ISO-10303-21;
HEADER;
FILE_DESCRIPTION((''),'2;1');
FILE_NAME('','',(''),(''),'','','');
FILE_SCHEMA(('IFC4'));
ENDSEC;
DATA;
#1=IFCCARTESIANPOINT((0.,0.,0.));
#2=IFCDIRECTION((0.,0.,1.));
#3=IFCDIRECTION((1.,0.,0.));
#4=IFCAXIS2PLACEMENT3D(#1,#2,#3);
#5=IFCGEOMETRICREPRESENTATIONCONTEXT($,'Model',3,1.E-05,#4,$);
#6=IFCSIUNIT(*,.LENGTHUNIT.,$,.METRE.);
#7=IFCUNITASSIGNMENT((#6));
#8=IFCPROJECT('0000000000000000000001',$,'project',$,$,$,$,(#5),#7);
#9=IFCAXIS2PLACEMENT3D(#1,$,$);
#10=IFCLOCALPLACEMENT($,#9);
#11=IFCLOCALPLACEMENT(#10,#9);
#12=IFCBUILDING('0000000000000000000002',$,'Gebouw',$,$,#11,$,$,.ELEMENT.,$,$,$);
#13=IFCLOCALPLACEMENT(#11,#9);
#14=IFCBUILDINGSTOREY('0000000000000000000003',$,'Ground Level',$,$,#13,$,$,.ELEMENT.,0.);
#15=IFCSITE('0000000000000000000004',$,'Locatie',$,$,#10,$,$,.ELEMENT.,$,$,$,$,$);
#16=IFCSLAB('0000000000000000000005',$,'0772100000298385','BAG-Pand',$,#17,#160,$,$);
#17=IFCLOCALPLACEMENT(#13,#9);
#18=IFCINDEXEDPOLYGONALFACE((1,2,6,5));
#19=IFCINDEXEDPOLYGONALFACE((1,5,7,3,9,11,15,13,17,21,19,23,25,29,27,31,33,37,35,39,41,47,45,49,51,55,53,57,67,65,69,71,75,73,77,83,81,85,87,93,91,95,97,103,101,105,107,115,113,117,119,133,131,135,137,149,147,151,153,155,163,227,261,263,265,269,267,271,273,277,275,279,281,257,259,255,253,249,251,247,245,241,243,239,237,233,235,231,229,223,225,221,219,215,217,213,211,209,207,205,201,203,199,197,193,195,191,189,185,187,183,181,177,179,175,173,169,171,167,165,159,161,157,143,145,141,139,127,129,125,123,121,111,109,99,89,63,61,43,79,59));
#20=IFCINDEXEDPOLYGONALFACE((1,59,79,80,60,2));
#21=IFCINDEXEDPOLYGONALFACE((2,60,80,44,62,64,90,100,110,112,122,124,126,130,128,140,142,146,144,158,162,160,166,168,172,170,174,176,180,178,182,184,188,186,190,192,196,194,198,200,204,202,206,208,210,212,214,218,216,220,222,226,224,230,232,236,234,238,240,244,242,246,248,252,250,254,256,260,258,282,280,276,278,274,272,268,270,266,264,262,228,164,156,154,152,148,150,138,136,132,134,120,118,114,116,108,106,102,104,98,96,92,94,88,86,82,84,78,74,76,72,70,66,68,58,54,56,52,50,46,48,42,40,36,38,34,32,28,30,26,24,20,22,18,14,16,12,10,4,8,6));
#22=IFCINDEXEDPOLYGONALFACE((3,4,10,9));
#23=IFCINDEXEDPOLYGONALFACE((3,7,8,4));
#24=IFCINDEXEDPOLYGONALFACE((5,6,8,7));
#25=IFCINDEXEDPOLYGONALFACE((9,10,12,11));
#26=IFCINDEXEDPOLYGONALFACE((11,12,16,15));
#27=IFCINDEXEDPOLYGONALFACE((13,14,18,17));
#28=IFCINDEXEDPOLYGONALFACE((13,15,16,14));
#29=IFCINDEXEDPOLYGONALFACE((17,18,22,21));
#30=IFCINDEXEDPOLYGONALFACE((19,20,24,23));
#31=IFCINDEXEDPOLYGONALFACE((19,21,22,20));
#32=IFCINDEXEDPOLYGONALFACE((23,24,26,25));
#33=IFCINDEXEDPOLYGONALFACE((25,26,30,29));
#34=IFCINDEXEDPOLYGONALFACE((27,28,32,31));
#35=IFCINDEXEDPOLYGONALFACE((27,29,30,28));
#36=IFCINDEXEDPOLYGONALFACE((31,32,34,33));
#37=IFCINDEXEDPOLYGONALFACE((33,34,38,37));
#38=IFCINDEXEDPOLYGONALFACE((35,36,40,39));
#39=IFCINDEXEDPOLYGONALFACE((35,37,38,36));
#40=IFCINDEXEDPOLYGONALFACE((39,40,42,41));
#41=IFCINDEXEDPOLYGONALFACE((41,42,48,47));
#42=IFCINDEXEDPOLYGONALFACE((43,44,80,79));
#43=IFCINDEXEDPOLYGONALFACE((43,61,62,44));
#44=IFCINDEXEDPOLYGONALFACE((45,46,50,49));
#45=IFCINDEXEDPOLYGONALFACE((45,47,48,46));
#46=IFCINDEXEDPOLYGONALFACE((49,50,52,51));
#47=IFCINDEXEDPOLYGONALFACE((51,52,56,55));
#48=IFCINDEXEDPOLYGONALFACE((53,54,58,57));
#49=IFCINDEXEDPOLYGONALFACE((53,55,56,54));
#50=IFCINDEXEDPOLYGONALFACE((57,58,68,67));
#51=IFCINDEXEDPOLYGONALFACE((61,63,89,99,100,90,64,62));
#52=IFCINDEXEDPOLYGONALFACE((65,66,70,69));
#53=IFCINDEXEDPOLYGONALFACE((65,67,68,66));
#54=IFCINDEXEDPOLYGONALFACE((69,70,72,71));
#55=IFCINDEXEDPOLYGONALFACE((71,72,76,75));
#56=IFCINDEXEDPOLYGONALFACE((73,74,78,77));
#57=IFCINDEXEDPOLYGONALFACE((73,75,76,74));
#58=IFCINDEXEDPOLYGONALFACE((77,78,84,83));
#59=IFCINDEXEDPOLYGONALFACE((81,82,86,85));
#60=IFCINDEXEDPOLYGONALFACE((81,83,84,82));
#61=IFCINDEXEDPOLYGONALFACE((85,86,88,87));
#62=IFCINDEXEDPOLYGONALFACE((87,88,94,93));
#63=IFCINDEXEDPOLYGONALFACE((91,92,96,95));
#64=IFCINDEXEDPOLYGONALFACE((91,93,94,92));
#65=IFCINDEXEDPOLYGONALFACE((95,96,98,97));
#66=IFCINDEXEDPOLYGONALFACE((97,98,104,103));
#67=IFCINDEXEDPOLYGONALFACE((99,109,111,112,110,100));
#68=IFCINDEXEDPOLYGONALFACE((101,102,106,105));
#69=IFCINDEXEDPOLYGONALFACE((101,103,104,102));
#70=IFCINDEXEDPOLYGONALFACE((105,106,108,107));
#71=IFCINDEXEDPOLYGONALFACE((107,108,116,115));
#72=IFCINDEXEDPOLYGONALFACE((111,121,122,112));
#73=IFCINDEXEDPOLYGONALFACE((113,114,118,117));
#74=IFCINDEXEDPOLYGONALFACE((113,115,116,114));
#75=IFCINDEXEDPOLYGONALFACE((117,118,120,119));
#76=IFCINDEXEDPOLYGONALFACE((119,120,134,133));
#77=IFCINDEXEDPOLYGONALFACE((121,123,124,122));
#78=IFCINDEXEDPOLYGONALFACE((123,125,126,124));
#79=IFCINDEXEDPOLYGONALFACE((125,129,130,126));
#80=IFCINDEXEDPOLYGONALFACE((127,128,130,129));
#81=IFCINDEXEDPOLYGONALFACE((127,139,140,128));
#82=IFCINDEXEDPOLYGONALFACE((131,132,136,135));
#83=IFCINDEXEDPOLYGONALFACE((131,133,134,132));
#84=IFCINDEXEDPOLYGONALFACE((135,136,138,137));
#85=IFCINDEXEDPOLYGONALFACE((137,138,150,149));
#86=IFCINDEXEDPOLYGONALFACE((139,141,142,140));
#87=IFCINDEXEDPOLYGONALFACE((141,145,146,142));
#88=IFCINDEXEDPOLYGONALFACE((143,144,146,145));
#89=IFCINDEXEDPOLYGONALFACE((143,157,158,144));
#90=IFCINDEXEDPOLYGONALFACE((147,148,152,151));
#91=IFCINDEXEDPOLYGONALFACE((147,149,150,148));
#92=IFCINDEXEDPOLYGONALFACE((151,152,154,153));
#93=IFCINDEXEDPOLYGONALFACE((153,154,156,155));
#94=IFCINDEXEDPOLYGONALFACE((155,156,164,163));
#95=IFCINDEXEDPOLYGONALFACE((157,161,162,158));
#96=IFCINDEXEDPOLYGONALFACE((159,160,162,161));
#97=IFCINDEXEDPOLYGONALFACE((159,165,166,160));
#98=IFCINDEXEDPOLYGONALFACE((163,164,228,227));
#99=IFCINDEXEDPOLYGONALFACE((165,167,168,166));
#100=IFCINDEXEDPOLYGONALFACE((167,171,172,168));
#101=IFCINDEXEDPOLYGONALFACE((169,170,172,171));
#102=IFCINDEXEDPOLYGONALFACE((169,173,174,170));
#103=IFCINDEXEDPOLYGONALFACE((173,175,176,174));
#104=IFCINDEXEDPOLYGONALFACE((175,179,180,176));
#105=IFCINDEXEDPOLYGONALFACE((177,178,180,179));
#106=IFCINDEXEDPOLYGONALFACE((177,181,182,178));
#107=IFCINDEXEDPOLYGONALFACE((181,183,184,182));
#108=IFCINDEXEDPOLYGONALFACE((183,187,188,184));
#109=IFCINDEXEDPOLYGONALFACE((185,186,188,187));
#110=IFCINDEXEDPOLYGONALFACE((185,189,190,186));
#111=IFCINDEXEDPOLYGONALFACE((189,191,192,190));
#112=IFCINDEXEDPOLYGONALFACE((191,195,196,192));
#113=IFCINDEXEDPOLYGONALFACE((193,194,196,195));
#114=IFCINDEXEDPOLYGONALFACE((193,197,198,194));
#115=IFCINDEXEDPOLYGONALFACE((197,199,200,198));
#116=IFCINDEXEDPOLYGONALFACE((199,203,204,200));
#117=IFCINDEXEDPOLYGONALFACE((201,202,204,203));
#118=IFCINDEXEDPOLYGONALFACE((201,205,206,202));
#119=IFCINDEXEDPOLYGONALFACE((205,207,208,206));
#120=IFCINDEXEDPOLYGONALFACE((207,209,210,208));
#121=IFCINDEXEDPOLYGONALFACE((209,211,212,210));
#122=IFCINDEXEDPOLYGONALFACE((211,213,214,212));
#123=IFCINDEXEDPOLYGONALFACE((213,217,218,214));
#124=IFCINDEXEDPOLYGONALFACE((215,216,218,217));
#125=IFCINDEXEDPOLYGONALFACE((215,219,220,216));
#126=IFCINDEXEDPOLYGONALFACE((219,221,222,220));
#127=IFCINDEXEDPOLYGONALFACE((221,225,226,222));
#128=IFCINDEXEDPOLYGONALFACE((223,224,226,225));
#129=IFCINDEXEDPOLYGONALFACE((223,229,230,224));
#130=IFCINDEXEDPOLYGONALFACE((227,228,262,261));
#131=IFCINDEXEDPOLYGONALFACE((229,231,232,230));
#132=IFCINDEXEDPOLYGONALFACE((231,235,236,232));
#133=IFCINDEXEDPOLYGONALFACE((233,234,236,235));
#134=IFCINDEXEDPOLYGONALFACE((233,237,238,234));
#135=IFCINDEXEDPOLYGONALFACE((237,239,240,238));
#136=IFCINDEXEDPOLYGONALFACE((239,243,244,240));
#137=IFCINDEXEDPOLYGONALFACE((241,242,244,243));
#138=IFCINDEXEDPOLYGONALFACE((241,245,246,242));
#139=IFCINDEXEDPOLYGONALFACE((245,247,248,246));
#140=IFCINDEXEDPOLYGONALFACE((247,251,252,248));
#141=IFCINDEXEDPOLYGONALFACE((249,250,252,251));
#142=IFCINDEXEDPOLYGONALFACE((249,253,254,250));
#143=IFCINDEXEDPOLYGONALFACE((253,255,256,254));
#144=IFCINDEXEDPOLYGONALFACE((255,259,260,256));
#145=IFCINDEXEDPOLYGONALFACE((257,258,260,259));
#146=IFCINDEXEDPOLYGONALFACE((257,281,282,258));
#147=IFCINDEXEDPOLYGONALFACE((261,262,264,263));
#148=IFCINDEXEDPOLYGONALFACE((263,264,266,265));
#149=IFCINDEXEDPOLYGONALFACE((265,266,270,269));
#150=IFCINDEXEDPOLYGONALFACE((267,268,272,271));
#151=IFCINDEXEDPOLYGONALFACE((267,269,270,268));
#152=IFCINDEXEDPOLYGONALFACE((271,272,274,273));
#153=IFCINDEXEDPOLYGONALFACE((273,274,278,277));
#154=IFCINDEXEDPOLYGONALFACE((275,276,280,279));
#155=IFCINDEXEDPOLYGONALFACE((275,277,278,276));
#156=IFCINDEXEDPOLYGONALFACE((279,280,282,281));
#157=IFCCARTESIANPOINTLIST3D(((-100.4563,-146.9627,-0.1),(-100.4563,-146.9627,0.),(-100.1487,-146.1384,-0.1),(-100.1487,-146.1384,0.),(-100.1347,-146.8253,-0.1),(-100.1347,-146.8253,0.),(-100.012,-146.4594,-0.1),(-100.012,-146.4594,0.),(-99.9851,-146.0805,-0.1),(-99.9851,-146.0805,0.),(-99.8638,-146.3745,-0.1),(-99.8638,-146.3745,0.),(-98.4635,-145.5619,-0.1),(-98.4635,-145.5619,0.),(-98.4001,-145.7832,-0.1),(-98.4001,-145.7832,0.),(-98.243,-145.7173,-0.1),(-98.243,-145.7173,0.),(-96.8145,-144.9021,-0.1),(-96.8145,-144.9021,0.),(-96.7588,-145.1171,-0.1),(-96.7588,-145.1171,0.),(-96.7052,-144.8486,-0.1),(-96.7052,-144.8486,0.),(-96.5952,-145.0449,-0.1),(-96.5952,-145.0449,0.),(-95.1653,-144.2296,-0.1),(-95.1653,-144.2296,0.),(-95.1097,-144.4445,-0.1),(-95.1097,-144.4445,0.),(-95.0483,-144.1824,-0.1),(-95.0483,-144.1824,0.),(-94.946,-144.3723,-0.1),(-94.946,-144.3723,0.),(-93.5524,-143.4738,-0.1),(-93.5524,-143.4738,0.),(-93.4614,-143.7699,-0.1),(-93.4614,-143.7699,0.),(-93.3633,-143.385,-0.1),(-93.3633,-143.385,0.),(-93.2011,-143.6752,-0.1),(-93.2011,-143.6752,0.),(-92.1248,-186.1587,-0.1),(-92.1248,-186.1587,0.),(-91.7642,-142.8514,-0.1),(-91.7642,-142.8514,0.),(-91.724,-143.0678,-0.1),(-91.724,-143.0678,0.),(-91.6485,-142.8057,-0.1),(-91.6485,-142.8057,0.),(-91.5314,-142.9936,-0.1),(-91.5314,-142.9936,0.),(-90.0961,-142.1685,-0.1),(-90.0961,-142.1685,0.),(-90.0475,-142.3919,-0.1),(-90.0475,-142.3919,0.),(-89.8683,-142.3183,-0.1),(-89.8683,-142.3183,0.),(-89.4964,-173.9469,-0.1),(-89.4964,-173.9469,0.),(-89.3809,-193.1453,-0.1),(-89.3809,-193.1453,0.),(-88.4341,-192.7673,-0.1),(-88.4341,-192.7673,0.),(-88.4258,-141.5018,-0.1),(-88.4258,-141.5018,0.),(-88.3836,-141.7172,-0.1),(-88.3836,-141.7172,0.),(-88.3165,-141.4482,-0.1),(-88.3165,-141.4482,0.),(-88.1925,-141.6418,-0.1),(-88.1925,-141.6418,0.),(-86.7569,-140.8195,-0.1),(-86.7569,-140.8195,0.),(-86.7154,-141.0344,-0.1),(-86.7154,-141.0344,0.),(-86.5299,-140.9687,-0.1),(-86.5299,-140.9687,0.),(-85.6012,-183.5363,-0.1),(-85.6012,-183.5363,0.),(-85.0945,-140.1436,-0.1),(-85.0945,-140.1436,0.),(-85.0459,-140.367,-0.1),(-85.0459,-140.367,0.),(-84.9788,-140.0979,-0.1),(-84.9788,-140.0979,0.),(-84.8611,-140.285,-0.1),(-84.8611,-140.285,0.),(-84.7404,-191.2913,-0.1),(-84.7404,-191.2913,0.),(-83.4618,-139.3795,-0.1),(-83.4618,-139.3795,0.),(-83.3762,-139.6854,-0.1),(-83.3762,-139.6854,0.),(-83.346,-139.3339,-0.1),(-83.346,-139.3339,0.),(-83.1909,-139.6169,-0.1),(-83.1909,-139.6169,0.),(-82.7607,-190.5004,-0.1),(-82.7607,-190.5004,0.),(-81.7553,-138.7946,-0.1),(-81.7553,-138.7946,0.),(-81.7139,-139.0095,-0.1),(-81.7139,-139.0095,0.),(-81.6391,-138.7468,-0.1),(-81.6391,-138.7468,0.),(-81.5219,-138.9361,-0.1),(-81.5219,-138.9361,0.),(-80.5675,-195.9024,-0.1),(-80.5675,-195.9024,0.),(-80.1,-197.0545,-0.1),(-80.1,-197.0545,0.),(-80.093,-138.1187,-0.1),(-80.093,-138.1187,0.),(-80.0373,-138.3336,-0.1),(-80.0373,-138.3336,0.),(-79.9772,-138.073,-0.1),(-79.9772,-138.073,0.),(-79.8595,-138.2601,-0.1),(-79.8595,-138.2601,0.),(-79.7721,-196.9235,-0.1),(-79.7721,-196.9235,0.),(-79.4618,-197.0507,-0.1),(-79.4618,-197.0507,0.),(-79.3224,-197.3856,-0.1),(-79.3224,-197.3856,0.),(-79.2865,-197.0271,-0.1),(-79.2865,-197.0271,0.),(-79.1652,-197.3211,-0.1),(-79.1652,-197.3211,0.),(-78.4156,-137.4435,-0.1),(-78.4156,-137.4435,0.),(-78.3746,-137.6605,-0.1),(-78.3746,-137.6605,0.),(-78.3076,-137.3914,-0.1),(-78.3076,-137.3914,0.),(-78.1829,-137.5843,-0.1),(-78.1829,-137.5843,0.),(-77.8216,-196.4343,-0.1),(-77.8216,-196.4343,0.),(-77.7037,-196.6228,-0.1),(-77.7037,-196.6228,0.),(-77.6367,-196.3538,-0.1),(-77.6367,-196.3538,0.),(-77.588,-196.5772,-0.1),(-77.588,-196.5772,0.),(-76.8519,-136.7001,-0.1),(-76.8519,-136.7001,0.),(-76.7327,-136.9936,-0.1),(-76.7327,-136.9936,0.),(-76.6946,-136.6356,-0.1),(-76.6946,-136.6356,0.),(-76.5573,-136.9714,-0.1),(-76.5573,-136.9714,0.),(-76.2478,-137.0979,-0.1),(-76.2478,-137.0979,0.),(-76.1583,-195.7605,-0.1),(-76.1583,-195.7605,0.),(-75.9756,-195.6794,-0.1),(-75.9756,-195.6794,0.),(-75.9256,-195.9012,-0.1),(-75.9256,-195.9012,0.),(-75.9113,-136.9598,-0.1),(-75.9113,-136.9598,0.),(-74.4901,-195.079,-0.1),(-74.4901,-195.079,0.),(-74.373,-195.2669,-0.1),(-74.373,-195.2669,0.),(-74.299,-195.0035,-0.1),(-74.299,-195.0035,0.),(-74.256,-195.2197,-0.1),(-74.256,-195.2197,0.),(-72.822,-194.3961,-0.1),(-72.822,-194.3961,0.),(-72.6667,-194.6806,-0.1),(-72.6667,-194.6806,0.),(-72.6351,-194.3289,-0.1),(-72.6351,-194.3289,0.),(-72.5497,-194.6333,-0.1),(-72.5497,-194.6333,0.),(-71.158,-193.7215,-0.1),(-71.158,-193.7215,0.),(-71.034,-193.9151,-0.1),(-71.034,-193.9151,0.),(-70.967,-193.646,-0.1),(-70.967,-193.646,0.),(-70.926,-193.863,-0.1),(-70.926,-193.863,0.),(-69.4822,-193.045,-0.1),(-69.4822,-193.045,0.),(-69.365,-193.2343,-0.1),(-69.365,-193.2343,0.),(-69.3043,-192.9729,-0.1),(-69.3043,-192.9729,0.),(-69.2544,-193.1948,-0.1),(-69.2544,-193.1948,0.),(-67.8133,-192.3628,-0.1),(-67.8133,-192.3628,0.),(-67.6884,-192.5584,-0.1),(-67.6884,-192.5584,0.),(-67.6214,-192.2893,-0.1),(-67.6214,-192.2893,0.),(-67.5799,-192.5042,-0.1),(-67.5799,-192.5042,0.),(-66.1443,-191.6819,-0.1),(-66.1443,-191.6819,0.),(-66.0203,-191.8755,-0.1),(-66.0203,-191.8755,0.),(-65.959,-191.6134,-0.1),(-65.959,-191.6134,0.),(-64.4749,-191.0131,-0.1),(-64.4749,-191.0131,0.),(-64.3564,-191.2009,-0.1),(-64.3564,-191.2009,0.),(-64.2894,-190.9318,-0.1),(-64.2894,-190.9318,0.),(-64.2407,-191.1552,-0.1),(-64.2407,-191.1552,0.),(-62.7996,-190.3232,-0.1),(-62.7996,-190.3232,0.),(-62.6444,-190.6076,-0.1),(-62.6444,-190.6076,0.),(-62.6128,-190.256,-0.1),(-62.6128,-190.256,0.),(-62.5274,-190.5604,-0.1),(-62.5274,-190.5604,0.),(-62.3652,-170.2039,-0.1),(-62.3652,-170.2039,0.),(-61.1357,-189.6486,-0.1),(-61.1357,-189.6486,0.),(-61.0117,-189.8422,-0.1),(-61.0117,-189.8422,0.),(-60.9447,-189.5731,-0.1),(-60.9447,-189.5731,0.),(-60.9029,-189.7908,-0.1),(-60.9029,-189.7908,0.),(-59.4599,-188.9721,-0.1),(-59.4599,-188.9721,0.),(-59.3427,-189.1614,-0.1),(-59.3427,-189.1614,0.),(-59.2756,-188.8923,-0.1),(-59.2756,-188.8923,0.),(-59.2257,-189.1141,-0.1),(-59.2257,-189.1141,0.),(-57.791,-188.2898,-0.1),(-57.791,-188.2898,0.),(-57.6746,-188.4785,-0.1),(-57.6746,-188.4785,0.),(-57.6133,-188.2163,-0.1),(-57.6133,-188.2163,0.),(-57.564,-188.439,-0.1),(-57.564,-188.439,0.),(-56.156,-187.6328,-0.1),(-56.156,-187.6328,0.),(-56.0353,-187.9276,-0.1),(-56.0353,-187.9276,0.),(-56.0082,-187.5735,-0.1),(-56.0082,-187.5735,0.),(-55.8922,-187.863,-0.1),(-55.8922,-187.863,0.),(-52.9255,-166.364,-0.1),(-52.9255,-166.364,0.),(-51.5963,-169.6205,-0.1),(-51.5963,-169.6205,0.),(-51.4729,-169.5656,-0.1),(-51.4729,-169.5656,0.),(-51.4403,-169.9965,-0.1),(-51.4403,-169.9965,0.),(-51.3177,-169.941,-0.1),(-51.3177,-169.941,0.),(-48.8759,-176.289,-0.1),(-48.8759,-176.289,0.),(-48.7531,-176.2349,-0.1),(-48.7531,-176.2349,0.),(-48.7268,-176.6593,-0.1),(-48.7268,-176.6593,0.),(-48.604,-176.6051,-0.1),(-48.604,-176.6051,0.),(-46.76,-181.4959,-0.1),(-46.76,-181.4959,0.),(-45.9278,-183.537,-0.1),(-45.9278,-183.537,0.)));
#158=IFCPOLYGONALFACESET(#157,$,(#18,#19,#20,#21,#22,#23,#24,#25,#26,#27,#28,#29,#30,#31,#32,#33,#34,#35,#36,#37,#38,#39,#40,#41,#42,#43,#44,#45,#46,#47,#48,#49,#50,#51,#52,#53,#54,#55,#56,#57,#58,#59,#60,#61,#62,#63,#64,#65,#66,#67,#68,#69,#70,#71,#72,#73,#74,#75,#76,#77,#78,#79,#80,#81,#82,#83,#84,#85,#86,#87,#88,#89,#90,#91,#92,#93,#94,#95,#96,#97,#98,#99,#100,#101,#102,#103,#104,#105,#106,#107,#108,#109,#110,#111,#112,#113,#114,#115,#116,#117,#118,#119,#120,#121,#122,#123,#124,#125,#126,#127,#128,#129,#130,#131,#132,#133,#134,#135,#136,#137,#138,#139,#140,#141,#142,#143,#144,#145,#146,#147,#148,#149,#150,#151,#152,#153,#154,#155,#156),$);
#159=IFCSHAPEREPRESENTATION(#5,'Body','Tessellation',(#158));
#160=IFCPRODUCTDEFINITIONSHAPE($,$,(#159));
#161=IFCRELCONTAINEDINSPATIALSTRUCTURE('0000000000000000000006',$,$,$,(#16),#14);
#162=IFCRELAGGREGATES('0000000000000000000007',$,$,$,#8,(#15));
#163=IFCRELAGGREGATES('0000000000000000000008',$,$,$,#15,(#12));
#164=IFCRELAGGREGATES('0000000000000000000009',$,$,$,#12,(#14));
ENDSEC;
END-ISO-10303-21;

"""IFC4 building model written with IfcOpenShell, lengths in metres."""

from ifc_helpers import new_model, si_unit, frame, origin, origin_with_axes, place, context, project, spatial, polyline, outline, extrude, element, save


model = new_model("IFC4")

# Units and contexts
model_context = context("Model", 3, precision=1e-05, world=origin_with_axes())
ifc_project = project(units=[si_unit("LENGTHUNIT", "METRE")], contexts=[model_context])

# Site, building, storey
site_placement = place(None, origin())
site = spatial("IfcSite", under=ifc_project, at=site_placement, Name="Locatie", CompositionType="ELEMENT")
building_placement = place(site_placement, origin())
building = spatial("IfcBuilding", under=site, at=building_placement, Name="Gebouw", CompositionType="ELEMENT")
storey_placement = place(building_placement, origin())
storey = spatial("IfcBuildingStorey", under=building, at=storey_placement, Name="Ground Level", CompositionType="ELEMENT", Elevation=0.0)

# Slab
slab_1_placement = place(storey_placement, origin())
element("IfcSlab", 1, at=slab_1_placement, inside=storey, Name="0772100000298385", Description="BAG-Pand", context=model_context, shape_type="SweptSolid", body=[
    extrude(outline(polyline([(-88.4341, -192.7673), (-89.3809, -193.1453), (-92.1248, -186.1587), (-85.6012, -183.5363), (-89.4964, -173.9469), (-100.4563, -146.9627), (-100.1347, -146.8253), (-100.012, -146.4594), (-100.1487, -146.1384), (-99.9851, -146.0805), (-99.8638, -146.3745), (-98.4001, -145.7832), (-98.4635, -145.5619), (-98.243, -145.7173), (-96.7588, -145.1171), (-96.8145, -144.9021), (-96.7052, -144.8486), (-96.5952, -145.0449), (-95.1097, -144.4445), (-95.1653, -144.2296), (-95.0483, -144.1824), (-94.946, -144.3723), (-93.4614, -143.7699), (-93.5524, -143.4738), (-93.3633, -143.385), (-93.2011, -143.6752), (-91.724, -143.0678), (-91.7642, -142.8514), (-91.6485, -142.8057), (-91.5314, -142.9936), (-90.0475, -142.3919), (-90.0961, -142.1685), (-89.8683, -142.3183), (-88.3836, -141.7172), (-88.4258, -141.5018), (-88.3165, -141.4482), (-88.1925, -141.6418), (-86.7154, -141.0344), (-86.7569, -140.8195), (-86.5299, -140.9687), (-85.0459, -140.367), (-85.0945, -140.1436), (-84.9788, -140.0979), (-84.8611, -140.285), (-83.3762, -139.6854), (-83.4618, -139.3795), (-83.346, -139.3339), (-83.1909, -139.6169), (-81.7139, -139.0095), (-81.7553, -138.7946), (-81.6391, -138.7468), (-81.5219, -138.9361), (-80.0373, -138.3336), (-80.093, -138.1187), (-79.9772, -138.073), (-79.8595, -138.2601), (-78.3746, -137.6605), (-78.4156, -137.4435), (-78.3076, -137.3914), (-78.1829, -137.5843), (-76.7327, -136.9936), (-76.8519, -136.7001), (-76.6946, -136.6356), (-76.5573, -136.9714), (-76.2478, -137.0979), (-75.9113, -136.9598), (-62.3652, -170.2039), (-52.9255, -166.364), (-51.5963, -169.6205), (-51.4729, -169.5656), (-51.3177, -169.941), (-51.4403, -169.9965), (-48.8759, -176.289), (-48.7531, -176.2349), (-48.604, -176.6051), (-48.7268, -176.6593), (-46.76, -181.4959), (-45.9278, -183.537), (-56.0082, -187.5735), (-55.8922, -187.863), (-56.0353, -187.9276), (-56.156, -187.6328), (-57.6133, -188.2163), (-57.564, -188.439), (-57.6746, -188.4785), (-57.791, -188.2898), (-59.2756, -188.8923), (-59.2257, -189.1141), (-59.3427, -189.1614), (-59.4599, -188.9721), (-60.9447, -189.5731), (-60.9029, -189.7908), (-61.0117, -189.8422), (-61.1357, -189.6486), (-62.6128, -190.256), (-62.5274, -190.5604), (-62.6444, -190.6076), (-62.7996, -190.3232), (-64.2894, -190.9318), (-64.2407, -191.1552), (-64.3564, -191.2009), (-64.4749, -191.0131), (-65.959, -191.6134), (-66.0203, -191.8755), (-66.1443, -191.6819), (-67.6214, -192.2893), (-67.5799, -192.5042), (-67.6884, -192.5584), (-67.8133, -192.3628), (-69.3043, -192.9729), (-69.2544, -193.1948), (-69.365, -193.2343), (-69.4822, -193.045), (-70.967, -193.646), (-70.926, -193.863), (-71.034, -193.9151), (-71.158, -193.7215), (-72.6351, -194.3289), (-72.5497, -194.6333), (-72.6667, -194.6806), (-72.822, -194.3961), (-74.299, -195.0035), (-74.256, -195.2197), (-74.373, -195.2669), (-74.4901, -195.079), (-75.9756, -195.6794), (-75.9256, -195.9012), (-76.1583, -195.7605), (-77.6367, -196.3538), (-77.588, -196.5772), (-77.7037, -196.6228), (-77.8216, -196.4343), (-79.2865, -197.0271), (-79.1652, -197.3211), (-79.3224, -197.3856), (-79.4618, -197.0507), (-79.7721, -196.9235), (-80.1, -197.0545), (-80.5675, -195.9024), (-82.7607, -190.5004), (-84.7404, -191.2913), (-88.4341, -192.7673)])), frame((0.0, 0.0, -0.1), z_axis=(0.0, 0.0, 1.0), x_axis=(1.0, 0.0, 0.0)), (0.0, 0.0, 1.0), 0.1),
])

save(model, "model.ifc")
